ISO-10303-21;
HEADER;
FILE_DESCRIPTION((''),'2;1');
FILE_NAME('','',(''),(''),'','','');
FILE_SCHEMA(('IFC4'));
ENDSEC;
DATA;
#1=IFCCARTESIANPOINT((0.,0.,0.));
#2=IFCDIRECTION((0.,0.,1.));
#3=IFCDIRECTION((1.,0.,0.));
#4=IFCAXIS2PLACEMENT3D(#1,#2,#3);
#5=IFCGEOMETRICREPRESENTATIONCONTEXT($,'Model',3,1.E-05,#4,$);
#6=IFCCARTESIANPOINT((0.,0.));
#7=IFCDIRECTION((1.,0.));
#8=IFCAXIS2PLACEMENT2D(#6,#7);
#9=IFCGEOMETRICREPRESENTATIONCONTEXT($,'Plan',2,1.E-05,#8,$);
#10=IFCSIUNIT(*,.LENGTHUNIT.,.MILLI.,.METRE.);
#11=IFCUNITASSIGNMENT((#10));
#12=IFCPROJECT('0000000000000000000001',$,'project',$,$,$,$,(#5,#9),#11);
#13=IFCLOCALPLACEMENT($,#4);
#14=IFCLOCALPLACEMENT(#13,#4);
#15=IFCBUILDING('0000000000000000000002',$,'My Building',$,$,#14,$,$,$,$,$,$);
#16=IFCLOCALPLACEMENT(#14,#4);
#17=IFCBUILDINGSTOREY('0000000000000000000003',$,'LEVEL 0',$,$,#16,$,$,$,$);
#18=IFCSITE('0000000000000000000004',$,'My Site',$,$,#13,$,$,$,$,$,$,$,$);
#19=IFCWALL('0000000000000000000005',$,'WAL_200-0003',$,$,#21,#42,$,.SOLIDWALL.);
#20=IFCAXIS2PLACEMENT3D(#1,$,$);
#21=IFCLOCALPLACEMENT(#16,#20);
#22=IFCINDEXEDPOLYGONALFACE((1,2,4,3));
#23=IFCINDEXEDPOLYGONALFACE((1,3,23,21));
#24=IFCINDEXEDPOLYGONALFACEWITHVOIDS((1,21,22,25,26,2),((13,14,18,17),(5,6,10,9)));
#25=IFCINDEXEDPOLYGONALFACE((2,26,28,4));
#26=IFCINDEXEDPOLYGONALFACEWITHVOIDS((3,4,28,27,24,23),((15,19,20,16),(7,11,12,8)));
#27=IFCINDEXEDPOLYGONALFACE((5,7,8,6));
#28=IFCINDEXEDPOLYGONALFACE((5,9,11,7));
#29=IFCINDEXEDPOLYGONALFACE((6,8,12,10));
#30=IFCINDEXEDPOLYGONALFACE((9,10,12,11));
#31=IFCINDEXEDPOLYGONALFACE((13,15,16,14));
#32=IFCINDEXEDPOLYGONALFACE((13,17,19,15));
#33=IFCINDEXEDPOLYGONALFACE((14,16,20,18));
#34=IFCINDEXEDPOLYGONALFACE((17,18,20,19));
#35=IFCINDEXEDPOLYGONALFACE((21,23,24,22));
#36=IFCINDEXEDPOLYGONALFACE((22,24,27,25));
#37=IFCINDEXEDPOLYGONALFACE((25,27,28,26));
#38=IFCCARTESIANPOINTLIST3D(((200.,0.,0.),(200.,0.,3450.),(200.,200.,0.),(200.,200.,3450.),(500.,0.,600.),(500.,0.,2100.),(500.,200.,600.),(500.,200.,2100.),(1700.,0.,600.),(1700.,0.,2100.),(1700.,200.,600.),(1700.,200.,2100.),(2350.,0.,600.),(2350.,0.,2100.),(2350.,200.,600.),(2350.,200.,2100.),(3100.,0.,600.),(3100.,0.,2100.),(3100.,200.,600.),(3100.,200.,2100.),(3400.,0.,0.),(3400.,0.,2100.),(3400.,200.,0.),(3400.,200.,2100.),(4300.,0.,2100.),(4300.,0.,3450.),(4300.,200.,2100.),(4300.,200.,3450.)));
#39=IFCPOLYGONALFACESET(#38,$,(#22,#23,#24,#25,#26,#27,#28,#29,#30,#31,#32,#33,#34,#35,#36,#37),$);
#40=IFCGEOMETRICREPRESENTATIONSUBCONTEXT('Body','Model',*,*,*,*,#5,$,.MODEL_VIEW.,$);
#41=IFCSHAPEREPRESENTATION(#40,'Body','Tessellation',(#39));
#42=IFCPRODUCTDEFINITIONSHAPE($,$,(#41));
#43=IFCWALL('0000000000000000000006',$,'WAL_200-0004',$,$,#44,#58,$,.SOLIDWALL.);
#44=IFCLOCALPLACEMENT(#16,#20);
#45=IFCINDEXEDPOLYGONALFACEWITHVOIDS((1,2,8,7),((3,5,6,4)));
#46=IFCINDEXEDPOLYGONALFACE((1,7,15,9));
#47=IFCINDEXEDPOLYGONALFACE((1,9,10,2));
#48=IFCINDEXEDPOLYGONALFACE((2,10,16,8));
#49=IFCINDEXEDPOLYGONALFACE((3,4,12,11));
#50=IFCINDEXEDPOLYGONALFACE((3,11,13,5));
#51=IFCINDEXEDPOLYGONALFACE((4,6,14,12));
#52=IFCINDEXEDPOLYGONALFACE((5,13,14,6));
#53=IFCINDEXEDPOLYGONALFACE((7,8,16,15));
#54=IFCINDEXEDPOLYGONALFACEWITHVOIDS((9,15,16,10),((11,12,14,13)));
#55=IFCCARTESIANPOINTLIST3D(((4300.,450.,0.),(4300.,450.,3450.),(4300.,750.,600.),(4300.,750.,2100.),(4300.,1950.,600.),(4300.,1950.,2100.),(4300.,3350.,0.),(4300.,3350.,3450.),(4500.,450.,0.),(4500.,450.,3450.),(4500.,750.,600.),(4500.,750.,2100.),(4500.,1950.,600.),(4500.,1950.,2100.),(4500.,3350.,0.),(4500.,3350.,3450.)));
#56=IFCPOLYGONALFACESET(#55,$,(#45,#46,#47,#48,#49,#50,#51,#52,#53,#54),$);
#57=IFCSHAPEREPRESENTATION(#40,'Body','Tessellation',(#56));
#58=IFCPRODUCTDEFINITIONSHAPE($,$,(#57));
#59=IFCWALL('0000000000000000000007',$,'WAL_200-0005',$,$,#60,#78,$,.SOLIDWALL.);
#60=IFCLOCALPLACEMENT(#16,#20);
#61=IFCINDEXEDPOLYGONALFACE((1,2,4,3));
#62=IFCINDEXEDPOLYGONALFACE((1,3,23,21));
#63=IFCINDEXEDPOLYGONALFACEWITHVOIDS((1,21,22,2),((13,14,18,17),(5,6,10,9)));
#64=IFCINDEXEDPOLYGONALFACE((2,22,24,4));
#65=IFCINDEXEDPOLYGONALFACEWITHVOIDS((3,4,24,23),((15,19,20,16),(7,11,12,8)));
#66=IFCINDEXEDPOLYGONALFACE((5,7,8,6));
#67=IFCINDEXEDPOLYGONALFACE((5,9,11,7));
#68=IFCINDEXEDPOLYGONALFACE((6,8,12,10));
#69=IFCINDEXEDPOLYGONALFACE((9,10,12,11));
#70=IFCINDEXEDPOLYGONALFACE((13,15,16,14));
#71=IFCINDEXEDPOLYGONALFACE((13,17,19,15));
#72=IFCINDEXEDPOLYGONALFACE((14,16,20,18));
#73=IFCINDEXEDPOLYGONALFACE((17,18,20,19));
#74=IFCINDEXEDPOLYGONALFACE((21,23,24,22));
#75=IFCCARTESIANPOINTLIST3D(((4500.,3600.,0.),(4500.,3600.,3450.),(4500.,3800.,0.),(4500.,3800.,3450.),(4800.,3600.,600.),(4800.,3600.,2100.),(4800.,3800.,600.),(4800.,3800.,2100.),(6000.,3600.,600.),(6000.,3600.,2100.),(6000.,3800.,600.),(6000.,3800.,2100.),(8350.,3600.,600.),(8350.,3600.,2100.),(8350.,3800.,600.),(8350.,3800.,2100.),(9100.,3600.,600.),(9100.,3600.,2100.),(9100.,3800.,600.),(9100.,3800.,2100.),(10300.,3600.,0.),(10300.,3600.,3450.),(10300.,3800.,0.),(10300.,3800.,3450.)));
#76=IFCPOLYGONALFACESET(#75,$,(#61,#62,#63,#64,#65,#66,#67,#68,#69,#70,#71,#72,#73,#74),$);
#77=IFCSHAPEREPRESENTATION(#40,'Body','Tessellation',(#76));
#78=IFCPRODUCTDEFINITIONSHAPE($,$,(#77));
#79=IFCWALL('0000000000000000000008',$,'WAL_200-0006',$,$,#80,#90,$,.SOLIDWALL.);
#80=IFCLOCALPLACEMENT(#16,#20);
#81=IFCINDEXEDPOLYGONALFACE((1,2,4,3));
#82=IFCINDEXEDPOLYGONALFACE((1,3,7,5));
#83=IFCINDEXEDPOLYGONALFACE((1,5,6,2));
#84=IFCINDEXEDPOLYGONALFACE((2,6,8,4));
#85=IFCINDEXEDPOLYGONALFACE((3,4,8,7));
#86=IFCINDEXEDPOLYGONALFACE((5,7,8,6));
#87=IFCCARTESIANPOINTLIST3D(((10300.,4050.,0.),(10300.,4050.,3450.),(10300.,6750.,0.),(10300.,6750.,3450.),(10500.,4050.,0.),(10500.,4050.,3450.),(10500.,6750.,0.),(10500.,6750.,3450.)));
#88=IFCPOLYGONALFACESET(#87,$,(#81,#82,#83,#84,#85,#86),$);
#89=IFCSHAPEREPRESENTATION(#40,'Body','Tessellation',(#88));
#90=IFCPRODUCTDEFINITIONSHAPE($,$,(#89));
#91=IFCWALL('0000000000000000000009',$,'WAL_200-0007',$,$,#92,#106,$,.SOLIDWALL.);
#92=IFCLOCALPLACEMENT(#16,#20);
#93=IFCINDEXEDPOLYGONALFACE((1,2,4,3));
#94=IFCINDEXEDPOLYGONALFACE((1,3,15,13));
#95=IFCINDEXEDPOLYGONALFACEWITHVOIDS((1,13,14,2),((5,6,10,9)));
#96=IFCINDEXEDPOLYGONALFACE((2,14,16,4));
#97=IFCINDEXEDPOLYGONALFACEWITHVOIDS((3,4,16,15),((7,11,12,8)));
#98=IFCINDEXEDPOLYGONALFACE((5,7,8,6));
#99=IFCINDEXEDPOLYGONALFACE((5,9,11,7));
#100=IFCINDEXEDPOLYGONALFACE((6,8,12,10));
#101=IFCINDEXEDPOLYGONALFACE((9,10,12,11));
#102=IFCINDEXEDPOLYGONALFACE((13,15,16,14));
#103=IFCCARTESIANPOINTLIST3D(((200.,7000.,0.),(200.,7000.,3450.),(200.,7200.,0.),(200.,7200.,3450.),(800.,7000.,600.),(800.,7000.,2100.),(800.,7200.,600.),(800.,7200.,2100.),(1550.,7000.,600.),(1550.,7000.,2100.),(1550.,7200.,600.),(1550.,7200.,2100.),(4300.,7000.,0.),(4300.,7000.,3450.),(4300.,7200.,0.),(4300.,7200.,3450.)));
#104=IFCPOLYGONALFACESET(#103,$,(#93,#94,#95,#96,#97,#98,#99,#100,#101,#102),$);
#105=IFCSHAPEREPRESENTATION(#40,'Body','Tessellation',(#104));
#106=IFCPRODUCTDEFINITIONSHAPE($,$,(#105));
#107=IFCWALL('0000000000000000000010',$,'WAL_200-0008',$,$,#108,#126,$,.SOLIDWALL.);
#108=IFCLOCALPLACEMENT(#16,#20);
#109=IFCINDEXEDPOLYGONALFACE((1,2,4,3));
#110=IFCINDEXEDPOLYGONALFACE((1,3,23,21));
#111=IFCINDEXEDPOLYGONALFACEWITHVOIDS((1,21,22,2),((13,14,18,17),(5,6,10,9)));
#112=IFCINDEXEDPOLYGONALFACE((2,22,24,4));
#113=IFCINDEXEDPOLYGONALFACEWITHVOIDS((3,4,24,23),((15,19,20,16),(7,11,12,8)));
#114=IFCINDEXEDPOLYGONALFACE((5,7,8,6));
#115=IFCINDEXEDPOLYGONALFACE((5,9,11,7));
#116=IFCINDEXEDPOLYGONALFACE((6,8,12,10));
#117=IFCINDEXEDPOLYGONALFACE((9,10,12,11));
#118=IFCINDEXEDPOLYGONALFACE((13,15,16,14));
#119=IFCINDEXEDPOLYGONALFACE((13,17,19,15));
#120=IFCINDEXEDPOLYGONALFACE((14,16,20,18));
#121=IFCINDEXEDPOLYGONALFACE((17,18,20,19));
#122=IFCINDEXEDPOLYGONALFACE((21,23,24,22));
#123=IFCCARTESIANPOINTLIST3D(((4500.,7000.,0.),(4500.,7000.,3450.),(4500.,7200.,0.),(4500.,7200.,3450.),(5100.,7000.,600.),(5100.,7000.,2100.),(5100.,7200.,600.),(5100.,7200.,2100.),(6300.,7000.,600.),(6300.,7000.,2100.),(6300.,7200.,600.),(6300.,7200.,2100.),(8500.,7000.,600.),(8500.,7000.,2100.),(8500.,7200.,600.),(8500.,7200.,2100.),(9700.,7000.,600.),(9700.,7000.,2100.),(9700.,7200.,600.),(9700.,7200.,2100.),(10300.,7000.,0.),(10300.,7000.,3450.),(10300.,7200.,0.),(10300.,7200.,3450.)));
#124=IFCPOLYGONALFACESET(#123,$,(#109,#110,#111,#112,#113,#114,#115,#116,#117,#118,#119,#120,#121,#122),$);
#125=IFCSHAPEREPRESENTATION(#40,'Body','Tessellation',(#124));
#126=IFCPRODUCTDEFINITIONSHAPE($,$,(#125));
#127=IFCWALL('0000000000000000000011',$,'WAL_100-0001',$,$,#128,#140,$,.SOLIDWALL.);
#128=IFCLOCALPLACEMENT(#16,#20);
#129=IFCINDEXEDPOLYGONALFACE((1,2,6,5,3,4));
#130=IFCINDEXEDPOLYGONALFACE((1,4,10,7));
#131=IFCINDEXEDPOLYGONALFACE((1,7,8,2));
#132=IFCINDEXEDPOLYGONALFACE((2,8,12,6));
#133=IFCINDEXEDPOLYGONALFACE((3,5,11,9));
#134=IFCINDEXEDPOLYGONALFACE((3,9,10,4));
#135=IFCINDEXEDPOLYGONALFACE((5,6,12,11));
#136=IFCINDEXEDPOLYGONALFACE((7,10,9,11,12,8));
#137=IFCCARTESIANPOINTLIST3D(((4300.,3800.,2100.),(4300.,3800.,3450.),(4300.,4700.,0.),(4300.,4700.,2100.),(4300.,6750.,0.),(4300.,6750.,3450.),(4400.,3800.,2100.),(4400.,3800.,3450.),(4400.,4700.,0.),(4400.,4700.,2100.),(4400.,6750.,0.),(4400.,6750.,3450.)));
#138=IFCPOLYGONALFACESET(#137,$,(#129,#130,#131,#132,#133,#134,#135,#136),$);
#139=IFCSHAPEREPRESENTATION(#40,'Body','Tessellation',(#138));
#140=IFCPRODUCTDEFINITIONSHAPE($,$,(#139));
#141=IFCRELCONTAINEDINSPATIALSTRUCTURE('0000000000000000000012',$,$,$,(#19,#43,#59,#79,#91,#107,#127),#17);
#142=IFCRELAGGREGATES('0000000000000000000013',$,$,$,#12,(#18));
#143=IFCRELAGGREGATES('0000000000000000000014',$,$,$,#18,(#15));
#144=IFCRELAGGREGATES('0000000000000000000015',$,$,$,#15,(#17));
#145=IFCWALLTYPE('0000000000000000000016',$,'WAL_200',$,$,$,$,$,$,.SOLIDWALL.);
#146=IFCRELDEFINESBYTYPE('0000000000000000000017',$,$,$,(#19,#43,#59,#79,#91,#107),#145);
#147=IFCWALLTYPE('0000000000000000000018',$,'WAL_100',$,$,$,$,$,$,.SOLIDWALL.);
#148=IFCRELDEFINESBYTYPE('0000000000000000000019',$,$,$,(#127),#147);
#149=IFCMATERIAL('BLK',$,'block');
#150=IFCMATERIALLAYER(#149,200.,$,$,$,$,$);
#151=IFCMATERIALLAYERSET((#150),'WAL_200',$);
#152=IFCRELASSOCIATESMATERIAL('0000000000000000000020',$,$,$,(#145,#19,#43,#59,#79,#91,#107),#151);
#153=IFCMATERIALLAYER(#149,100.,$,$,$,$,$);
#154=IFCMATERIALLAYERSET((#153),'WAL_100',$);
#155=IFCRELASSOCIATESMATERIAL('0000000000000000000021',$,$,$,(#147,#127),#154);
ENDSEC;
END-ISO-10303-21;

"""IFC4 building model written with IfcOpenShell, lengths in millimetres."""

from ifc_helpers import new_model, si_unit, frame, origin_with_axes, origin_2d_with_axis, place, context, subcontext, project, spatial, indexed_curve, outline, extrude, material, layer, layer_set, layer_usage, type_object, element, save


model = new_model("IFC4")

# Units and contexts
model_context = context("Model", 3, precision=1e-05, world=origin_with_axes())
plan_context = context("Plan", 2, precision=1e-05, world=origin_2d_with_axis())
body_context = subcontext(model_context, "Body", "Model", "MODEL_VIEW")
ifc_project = project(units=[si_unit("LENGTHUNIT", "METRE", prefix="MILLI")], contexts=[model_context, plan_context])

# Site, building, storey
site_placement = place(None, origin_with_axes())
site = spatial("IfcSite", under=ifc_project, at=site_placement, Name="My Site")
building_placement = place(site_placement, origin_with_axes())
building = spatial("IfcBuilding", under=site, at=building_placement, Name="My Building")
storey_placement = place(building_placement, origin_with_axes())
storey = spatial("IfcBuildingStorey", under=building, at=storey_placement, Name="LEVEL 0")

# Shared definitions
ifc_material_1 = material(Name="BLK", Category="block")
ifc_layer_1 = layer(ifc_material_1, 200.0)
ifc_layer_set_1 = layer_set([ifc_layer_1], Name="WAL_200")
wall_type_1 = type_object("IfcWallType", Name="WAL_200", PredefinedType="SOLIDWALL", material=ifc_layer_set_1)

# Wall, openings
ifc_layer_usage_1 = layer_usage(ifc_layer_set_1, "AXIS2", "POSITIVE", 0.0)
wall_1_placement = place(storey_placement, frame((200.0, 0.0, 0.0), z_axis=(0.0, 0.0, 1.0), x_axis=(1.0, 0.0, 0.0)))
wall_1 = element("IfcWall", 1, at=wall_1_placement, inside=storey, type_object=wall_type_1, material=ifc_layer_usage_1, Name="WAL_200-0003", PredefinedType="SOLIDWALL", context=body_context, shape_type="SweptSolid", body=[
    extrude(outline(indexed_curve([(0.0, 0.0), (0.0, 200.0), (4100.0, 200.0), (4100.0, 0.0), (0.0, 0.0)], self_intersect=False)), origin_with_axes(), (0.0, 0.0, 1.0), 3450.0),
])
opening_1_placement = place(wall_1_placement, frame((3200.0, 50.0, 0.0), z_axis=(0.0, 0.0, 1.0), x_axis=(1.0, 0.0, 0.0)))
element("IfcOpeningElement", 2, at=opening_1_placement, cuts=wall_1, PredefinedType="OPENING", context=body_context, shape_type="SweptSolid", body=[
    extrude(outline(indexed_curve([(0.0, 0.0), (0.0, 400.0), (900.0, 400.0), (900.0, 0.0), (0.0, 0.0)], self_intersect=False)), frame((0.0, -100.0, 0.0), z_axis=(0.0, 0.0, 1.0), x_axis=(1.0, 0.0, 0.0)), (0.0, 0.0, 1.0), 2100.0),
])
opening_2_placement = place(wall_1_placement, frame((2900.0, 200.0, 600.0), z_axis=(0.0, 0.0, 1.0), x_axis=(-1.0, 0.0, 0.0)))
element("IfcOpeningElement", 3, at=opening_2_placement, cuts=wall_1, PredefinedType="OPENING", context=body_context, shape_type="SweptSolid", body=[
    extrude(outline(indexed_curve([(0.0, 0.0), (0.0, 400.0), (750.0, 400.0), (750.0, 0.0), (0.0, 0.0)], self_intersect=False)), frame((0.0, -100.0, 0.0), z_axis=(0.0, 0.0, 1.0), x_axis=(1.0, 0.0, 0.0)), (0.0, 0.0, 1.0), 1500.0),
])
opening_3_placement = place(wall_1_placement, frame((1500.0, 200.0, 600.0), z_axis=(0.0, 0.0, 1.0), x_axis=(-1.0, 0.0, 0.0)))
element("IfcOpeningElement", 4, at=opening_3_placement, cuts=wall_1, PredefinedType="OPENING", context=body_context, shape_type="SweptSolid", body=[
    extrude(outline(indexed_curve([(0.0, 0.0), (0.0, 400.0), (1200.0, 400.0), (1200.0, 0.0), (0.0, 0.0)], self_intersect=False)), frame((0.0, -100.0, 0.0), z_axis=(0.0, 0.0, 1.0), x_axis=(1.0, 0.0, 0.0)), (0.0, 0.0, 1.0), 1500.0),
])

# Wall, opening
ifc_layer_usage_2 = layer_usage(ifc_layer_set_1, "AXIS2", "POSITIVE", 0.0)
wall_2_placement = place(storey_placement, frame((4500.0, 450.0, 0.0), z_axis=(0.0, 0.0, 1.0), x_axis=(0.0, 1.0, 0.0)))
wall_2 = element("IfcWall", 5, at=wall_2_placement, inside=storey, type_object=wall_type_1, material=ifc_layer_usage_2, Name="WAL_200-0004", PredefinedType="SOLIDWALL", context=body_context, shape_type="SweptSolid", body=[
    extrude(outline(indexed_curve([(0.0, 0.0), (0.0, 200.0), (2900.0, 200.0), (2900.0, 0.0), (0.0, 0.0)], self_intersect=False)), origin_with_axes(), (0.0, 0.0, 1.0), 3450.0),
])
opening_4_placement = place(wall_2_placement, frame((1500.0, 200.0, 600.0), z_axis=(0.0, 0.0, 1.0), x_axis=(-1.0, 0.0, 0.0)))
element("IfcOpeningElement", 6, at=opening_4_placement, cuts=wall_2, PredefinedType="OPENING", context=body_context, shape_type="SweptSolid", body=[
    extrude(outline(indexed_curve([(0.0, 0.0), (0.0, 400.0), (1200.0, 400.0), (1200.0, 0.0), (0.0, 0.0)], self_intersect=False)), frame((0.0, -100.0, 0.0), z_axis=(0.0, 0.0, 1.0), x_axis=(1.0, 0.0, 0.0)), (0.0, 0.0, 1.0), 1500.0),
])

# Wall, openings
ifc_layer_usage_3 = layer_usage(ifc_layer_set_1, "AXIS2", "POSITIVE", 0.0)
wall_3_placement = place(storey_placement, frame((4500.0, 3600.0, 0.0), z_axis=(0.0, 0.0, 1.0), x_axis=(1.0, 0.0, 0.0)))
wall_3 = element("IfcWall", 7, at=wall_3_placement, inside=storey, type_object=wall_type_1, material=ifc_layer_usage_3, Name="WAL_200-0005", PredefinedType="SOLIDWALL", context=body_context, shape_type="SweptSolid", body=[
    extrude(outline(indexed_curve([(0.0, 0.0), (0.0, 200.0), (5800.0, 200.0), (5800.0, 0.0), (0.0, 0.0)], self_intersect=False)), origin_with_axes(), (0.0, 0.0, 1.0), 3450.0),
])
opening_5_placement = place(wall_3_placement, frame((4600.0, 200.0, 600.0), z_axis=(0.0, 0.0, 1.0), x_axis=(-1.0, 0.0, 0.0)))
element("IfcOpeningElement", 8, at=opening_5_placement, cuts=wall_3, PredefinedType="OPENING", context=body_context, shape_type="SweptSolid", body=[
    extrude(outline(indexed_curve([(0.0, 0.0), (0.0, 400.0), (750.0, 400.0), (750.0, 0.0), (0.0, 0.0)], self_intersect=False)), frame((0.0, -100.0, 0.0), z_axis=(0.0, 0.0, 1.0), x_axis=(1.0, 0.0, 0.0)), (0.0, 0.0, 1.0), 1500.0),
])
opening_6_placement = place(wall_3_placement, frame((1500.0, 200.0, 600.0), z_axis=(0.0, 0.0, 1.0), x_axis=(-1.0, 0.0, 0.0)))
element("IfcOpeningElement", 9, at=opening_6_placement, cuts=wall_3, PredefinedType="OPENING", context=body_context, shape_type="SweptSolid", body=[
    extrude(outline(indexed_curve([(0.0, 0.0), (0.0, 400.0), (1200.0, 400.0), (1200.0, 0.0), (0.0, 0.0)], self_intersect=False)), frame((0.0, -100.0, 0.0), z_axis=(0.0, 0.0, 1.0), x_axis=(1.0, 0.0, 0.0)), (0.0, 0.0, 1.0), 1500.0),
])

# Wall
ifc_layer_usage_4 = layer_usage(ifc_layer_set_1, "AXIS2", "POSITIVE", 0.0)
wall_4_placement = place(storey_placement, frame((10500.0, 4050.0, 0.0), z_axis=(0.0, 0.0, 1.0), x_axis=(0.0, 1.0, 0.0)))
element("IfcWall", 10, at=wall_4_placement, inside=storey, type_object=wall_type_1, material=ifc_layer_usage_4, Name="WAL_200-0006", PredefinedType="SOLIDWALL", context=body_context, shape_type="SweptSolid", body=[
    extrude(outline(indexed_curve([(0.0, 0.0), (0.0, 200.0), (2700.0, 200.0), (2700.0, 0.0), (0.0, 0.0)], self_intersect=False)), origin_with_axes(), (0.0, 0.0, 1.0), 3450.0),
])

# Wall, opening
ifc_layer_usage_5 = layer_usage(ifc_layer_set_1, "AXIS2", "POSITIVE", 0.0)
wall_5_placement = place(storey_placement, frame((200.0, 7000.0, 0.0), z_axis=(0.0, 0.0, 1.0), x_axis=(1.0, 0.0, 0.0)))
wall_5 = element("IfcWall", 11, at=wall_5_placement, inside=storey, type_object=wall_type_1, material=ifc_layer_usage_5, Name="WAL_200-0007", PredefinedType="SOLIDWALL", context=body_context, shape_type="SweptSolid", body=[
    extrude(outline(indexed_curve([(0.0, 0.0), (0.0, 200.0), (4100.0, 200.0), (4100.0, 0.0), (0.0, 0.0)], self_intersect=False)), origin_with_axes(), (0.0, 0.0, 1.0), 3450.0),
])
opening_7_placement = place(wall_5_placement, frame((600.0, 0.0, 600.0), z_axis=(0.0, 0.0, 1.0), x_axis=(1.0, 0.0, 0.0)))
element("IfcOpeningElement", 12, at=opening_7_placement, cuts=wall_5, PredefinedType="OPENING", context=body_context, shape_type="SweptSolid", body=[
    extrude(outline(indexed_curve([(0.0, 0.0), (0.0, 400.0), (750.0, 400.0), (750.0, 0.0), (0.0, 0.0)], self_intersect=False)), frame((0.0, -100.0, 0.0), z_axis=(0.0, 0.0, 1.0), x_axis=(1.0, 0.0, 0.0)), (0.0, 0.0, 1.0), 1500.0),
])

# Wall, openings
ifc_layer_usage_6 = layer_usage(ifc_layer_set_1, "AXIS2", "POSITIVE", 0.0)
wall_6_placement = place(storey_placement, frame((4500.0, 7000.0, 0.0), z_axis=(0.0, 0.0, 1.0), x_axis=(1.0, 0.0, 0.0)))
wall_6 = element("IfcWall", 13, at=wall_6_placement, inside=storey, type_object=wall_type_1, material=ifc_layer_usage_6, Name="WAL_200-0008", PredefinedType="SOLIDWALL", context=body_context, shape_type="SweptSolid", body=[
    extrude(outline(indexed_curve([(0.0, 0.0), (0.0, 200.0), (5800.0, 200.0), (5800.0, 0.0), (0.0, 0.0)], self_intersect=False)), origin_with_axes(), (0.0, 0.0, 1.0), 3450.0),
])
opening_8_placement = place(wall_6_placement, frame((600.0, 0.0, 600.0), z_axis=(0.0, 0.0, 1.0), x_axis=(1.0, 0.0, 0.0)))
element("IfcOpeningElement", 14, at=opening_8_placement, cuts=wall_6, PredefinedType="OPENING", context=body_context, shape_type="SweptSolid", body=[
    extrude(outline(indexed_curve([(0.0, 0.0), (0.0, 400.0), (1200.0, 400.0), (1200.0, 0.0), (0.0, 0.0)], self_intersect=False)), frame((0.0, -100.0, 0.0), z_axis=(0.0, 0.0, 1.0), x_axis=(1.0, 0.0, 0.0)), (0.0, 0.0, 1.0), 1500.0),
])
opening_9_placement = place(wall_6_placement, frame((4000.0, 0.0, 600.0), z_axis=(0.0, 0.0, 1.0), x_axis=(1.0, 0.0, 0.0)))
element("IfcOpeningElement", 15, at=opening_9_placement, cuts=wall_6, PredefinedType="OPENING", context=body_context, shape_type="SweptSolid", body=[
    extrude(outline(indexed_curve([(0.0, 0.0), (0.0, 400.0), (1200.0, 400.0), (1200.0, 0.0), (0.0, 0.0)], self_intersect=False)), frame((0.0, -100.0, 0.0), z_axis=(0.0, 0.0, 1.0), x_axis=(1.0, 0.0, 0.0)), (0.0, 0.0, 1.0), 1500.0),
])

# Wall, opening
ifc_layer_2 = layer(ifc_material_1, 100.0)
ifc_layer_set_2 = layer_set([ifc_layer_2], Name="WAL_100")
ifc_layer_usage_7 = layer_usage(ifc_layer_set_2, "AXIS2", "POSITIVE", 0.0)
wall_type_2 = type_object("IfcWallType", Name="WAL_100", PredefinedType="SOLIDWALL", material=ifc_layer_set_2)
wall_7_placement = place(storey_placement, frame((4400.0, 3800.0, 0.0), z_axis=(0.0, 0.0, 1.0), x_axis=(0.0, 1.0, 0.0)))
wall_7 = element("IfcWall", 16, at=wall_7_placement, inside=storey, type_object=wall_type_2, material=ifc_layer_usage_7, Name="WAL_100-0001", PredefinedType="SOLIDWALL", context=body_context, shape_type="SweptSolid", body=[
    extrude(outline(indexed_curve([(0.0, 0.0), (0.0, 100.0), (2950.0, 100.0), (2950.0, 0.0), (0.0, 0.0)], self_intersect=False)), origin_with_axes(), (0.0, 0.0, 1.0), 3450.0),
])
opening_10_placement = place(wall_7_placement, origin_with_axes())
element("IfcOpeningElement", 17, at=opening_10_placement, cuts=wall_7, PredefinedType="OPENING", context=body_context, shape_type="SweptSolid", body=[
    extrude(outline(indexed_curve([(0.0, 0.0), (0.0, 400.0), (900.0, 400.0), (900.0, 0.0), (0.0, 0.0)], self_intersect=False)), frame((0.0, -100.0, 0.0), z_axis=(0.0, 0.0, 1.0), x_axis=(1.0, 0.0, 0.0)), (0.0, 0.0, 1.0), 2100.0),
])

save(model, "model.ifc")
